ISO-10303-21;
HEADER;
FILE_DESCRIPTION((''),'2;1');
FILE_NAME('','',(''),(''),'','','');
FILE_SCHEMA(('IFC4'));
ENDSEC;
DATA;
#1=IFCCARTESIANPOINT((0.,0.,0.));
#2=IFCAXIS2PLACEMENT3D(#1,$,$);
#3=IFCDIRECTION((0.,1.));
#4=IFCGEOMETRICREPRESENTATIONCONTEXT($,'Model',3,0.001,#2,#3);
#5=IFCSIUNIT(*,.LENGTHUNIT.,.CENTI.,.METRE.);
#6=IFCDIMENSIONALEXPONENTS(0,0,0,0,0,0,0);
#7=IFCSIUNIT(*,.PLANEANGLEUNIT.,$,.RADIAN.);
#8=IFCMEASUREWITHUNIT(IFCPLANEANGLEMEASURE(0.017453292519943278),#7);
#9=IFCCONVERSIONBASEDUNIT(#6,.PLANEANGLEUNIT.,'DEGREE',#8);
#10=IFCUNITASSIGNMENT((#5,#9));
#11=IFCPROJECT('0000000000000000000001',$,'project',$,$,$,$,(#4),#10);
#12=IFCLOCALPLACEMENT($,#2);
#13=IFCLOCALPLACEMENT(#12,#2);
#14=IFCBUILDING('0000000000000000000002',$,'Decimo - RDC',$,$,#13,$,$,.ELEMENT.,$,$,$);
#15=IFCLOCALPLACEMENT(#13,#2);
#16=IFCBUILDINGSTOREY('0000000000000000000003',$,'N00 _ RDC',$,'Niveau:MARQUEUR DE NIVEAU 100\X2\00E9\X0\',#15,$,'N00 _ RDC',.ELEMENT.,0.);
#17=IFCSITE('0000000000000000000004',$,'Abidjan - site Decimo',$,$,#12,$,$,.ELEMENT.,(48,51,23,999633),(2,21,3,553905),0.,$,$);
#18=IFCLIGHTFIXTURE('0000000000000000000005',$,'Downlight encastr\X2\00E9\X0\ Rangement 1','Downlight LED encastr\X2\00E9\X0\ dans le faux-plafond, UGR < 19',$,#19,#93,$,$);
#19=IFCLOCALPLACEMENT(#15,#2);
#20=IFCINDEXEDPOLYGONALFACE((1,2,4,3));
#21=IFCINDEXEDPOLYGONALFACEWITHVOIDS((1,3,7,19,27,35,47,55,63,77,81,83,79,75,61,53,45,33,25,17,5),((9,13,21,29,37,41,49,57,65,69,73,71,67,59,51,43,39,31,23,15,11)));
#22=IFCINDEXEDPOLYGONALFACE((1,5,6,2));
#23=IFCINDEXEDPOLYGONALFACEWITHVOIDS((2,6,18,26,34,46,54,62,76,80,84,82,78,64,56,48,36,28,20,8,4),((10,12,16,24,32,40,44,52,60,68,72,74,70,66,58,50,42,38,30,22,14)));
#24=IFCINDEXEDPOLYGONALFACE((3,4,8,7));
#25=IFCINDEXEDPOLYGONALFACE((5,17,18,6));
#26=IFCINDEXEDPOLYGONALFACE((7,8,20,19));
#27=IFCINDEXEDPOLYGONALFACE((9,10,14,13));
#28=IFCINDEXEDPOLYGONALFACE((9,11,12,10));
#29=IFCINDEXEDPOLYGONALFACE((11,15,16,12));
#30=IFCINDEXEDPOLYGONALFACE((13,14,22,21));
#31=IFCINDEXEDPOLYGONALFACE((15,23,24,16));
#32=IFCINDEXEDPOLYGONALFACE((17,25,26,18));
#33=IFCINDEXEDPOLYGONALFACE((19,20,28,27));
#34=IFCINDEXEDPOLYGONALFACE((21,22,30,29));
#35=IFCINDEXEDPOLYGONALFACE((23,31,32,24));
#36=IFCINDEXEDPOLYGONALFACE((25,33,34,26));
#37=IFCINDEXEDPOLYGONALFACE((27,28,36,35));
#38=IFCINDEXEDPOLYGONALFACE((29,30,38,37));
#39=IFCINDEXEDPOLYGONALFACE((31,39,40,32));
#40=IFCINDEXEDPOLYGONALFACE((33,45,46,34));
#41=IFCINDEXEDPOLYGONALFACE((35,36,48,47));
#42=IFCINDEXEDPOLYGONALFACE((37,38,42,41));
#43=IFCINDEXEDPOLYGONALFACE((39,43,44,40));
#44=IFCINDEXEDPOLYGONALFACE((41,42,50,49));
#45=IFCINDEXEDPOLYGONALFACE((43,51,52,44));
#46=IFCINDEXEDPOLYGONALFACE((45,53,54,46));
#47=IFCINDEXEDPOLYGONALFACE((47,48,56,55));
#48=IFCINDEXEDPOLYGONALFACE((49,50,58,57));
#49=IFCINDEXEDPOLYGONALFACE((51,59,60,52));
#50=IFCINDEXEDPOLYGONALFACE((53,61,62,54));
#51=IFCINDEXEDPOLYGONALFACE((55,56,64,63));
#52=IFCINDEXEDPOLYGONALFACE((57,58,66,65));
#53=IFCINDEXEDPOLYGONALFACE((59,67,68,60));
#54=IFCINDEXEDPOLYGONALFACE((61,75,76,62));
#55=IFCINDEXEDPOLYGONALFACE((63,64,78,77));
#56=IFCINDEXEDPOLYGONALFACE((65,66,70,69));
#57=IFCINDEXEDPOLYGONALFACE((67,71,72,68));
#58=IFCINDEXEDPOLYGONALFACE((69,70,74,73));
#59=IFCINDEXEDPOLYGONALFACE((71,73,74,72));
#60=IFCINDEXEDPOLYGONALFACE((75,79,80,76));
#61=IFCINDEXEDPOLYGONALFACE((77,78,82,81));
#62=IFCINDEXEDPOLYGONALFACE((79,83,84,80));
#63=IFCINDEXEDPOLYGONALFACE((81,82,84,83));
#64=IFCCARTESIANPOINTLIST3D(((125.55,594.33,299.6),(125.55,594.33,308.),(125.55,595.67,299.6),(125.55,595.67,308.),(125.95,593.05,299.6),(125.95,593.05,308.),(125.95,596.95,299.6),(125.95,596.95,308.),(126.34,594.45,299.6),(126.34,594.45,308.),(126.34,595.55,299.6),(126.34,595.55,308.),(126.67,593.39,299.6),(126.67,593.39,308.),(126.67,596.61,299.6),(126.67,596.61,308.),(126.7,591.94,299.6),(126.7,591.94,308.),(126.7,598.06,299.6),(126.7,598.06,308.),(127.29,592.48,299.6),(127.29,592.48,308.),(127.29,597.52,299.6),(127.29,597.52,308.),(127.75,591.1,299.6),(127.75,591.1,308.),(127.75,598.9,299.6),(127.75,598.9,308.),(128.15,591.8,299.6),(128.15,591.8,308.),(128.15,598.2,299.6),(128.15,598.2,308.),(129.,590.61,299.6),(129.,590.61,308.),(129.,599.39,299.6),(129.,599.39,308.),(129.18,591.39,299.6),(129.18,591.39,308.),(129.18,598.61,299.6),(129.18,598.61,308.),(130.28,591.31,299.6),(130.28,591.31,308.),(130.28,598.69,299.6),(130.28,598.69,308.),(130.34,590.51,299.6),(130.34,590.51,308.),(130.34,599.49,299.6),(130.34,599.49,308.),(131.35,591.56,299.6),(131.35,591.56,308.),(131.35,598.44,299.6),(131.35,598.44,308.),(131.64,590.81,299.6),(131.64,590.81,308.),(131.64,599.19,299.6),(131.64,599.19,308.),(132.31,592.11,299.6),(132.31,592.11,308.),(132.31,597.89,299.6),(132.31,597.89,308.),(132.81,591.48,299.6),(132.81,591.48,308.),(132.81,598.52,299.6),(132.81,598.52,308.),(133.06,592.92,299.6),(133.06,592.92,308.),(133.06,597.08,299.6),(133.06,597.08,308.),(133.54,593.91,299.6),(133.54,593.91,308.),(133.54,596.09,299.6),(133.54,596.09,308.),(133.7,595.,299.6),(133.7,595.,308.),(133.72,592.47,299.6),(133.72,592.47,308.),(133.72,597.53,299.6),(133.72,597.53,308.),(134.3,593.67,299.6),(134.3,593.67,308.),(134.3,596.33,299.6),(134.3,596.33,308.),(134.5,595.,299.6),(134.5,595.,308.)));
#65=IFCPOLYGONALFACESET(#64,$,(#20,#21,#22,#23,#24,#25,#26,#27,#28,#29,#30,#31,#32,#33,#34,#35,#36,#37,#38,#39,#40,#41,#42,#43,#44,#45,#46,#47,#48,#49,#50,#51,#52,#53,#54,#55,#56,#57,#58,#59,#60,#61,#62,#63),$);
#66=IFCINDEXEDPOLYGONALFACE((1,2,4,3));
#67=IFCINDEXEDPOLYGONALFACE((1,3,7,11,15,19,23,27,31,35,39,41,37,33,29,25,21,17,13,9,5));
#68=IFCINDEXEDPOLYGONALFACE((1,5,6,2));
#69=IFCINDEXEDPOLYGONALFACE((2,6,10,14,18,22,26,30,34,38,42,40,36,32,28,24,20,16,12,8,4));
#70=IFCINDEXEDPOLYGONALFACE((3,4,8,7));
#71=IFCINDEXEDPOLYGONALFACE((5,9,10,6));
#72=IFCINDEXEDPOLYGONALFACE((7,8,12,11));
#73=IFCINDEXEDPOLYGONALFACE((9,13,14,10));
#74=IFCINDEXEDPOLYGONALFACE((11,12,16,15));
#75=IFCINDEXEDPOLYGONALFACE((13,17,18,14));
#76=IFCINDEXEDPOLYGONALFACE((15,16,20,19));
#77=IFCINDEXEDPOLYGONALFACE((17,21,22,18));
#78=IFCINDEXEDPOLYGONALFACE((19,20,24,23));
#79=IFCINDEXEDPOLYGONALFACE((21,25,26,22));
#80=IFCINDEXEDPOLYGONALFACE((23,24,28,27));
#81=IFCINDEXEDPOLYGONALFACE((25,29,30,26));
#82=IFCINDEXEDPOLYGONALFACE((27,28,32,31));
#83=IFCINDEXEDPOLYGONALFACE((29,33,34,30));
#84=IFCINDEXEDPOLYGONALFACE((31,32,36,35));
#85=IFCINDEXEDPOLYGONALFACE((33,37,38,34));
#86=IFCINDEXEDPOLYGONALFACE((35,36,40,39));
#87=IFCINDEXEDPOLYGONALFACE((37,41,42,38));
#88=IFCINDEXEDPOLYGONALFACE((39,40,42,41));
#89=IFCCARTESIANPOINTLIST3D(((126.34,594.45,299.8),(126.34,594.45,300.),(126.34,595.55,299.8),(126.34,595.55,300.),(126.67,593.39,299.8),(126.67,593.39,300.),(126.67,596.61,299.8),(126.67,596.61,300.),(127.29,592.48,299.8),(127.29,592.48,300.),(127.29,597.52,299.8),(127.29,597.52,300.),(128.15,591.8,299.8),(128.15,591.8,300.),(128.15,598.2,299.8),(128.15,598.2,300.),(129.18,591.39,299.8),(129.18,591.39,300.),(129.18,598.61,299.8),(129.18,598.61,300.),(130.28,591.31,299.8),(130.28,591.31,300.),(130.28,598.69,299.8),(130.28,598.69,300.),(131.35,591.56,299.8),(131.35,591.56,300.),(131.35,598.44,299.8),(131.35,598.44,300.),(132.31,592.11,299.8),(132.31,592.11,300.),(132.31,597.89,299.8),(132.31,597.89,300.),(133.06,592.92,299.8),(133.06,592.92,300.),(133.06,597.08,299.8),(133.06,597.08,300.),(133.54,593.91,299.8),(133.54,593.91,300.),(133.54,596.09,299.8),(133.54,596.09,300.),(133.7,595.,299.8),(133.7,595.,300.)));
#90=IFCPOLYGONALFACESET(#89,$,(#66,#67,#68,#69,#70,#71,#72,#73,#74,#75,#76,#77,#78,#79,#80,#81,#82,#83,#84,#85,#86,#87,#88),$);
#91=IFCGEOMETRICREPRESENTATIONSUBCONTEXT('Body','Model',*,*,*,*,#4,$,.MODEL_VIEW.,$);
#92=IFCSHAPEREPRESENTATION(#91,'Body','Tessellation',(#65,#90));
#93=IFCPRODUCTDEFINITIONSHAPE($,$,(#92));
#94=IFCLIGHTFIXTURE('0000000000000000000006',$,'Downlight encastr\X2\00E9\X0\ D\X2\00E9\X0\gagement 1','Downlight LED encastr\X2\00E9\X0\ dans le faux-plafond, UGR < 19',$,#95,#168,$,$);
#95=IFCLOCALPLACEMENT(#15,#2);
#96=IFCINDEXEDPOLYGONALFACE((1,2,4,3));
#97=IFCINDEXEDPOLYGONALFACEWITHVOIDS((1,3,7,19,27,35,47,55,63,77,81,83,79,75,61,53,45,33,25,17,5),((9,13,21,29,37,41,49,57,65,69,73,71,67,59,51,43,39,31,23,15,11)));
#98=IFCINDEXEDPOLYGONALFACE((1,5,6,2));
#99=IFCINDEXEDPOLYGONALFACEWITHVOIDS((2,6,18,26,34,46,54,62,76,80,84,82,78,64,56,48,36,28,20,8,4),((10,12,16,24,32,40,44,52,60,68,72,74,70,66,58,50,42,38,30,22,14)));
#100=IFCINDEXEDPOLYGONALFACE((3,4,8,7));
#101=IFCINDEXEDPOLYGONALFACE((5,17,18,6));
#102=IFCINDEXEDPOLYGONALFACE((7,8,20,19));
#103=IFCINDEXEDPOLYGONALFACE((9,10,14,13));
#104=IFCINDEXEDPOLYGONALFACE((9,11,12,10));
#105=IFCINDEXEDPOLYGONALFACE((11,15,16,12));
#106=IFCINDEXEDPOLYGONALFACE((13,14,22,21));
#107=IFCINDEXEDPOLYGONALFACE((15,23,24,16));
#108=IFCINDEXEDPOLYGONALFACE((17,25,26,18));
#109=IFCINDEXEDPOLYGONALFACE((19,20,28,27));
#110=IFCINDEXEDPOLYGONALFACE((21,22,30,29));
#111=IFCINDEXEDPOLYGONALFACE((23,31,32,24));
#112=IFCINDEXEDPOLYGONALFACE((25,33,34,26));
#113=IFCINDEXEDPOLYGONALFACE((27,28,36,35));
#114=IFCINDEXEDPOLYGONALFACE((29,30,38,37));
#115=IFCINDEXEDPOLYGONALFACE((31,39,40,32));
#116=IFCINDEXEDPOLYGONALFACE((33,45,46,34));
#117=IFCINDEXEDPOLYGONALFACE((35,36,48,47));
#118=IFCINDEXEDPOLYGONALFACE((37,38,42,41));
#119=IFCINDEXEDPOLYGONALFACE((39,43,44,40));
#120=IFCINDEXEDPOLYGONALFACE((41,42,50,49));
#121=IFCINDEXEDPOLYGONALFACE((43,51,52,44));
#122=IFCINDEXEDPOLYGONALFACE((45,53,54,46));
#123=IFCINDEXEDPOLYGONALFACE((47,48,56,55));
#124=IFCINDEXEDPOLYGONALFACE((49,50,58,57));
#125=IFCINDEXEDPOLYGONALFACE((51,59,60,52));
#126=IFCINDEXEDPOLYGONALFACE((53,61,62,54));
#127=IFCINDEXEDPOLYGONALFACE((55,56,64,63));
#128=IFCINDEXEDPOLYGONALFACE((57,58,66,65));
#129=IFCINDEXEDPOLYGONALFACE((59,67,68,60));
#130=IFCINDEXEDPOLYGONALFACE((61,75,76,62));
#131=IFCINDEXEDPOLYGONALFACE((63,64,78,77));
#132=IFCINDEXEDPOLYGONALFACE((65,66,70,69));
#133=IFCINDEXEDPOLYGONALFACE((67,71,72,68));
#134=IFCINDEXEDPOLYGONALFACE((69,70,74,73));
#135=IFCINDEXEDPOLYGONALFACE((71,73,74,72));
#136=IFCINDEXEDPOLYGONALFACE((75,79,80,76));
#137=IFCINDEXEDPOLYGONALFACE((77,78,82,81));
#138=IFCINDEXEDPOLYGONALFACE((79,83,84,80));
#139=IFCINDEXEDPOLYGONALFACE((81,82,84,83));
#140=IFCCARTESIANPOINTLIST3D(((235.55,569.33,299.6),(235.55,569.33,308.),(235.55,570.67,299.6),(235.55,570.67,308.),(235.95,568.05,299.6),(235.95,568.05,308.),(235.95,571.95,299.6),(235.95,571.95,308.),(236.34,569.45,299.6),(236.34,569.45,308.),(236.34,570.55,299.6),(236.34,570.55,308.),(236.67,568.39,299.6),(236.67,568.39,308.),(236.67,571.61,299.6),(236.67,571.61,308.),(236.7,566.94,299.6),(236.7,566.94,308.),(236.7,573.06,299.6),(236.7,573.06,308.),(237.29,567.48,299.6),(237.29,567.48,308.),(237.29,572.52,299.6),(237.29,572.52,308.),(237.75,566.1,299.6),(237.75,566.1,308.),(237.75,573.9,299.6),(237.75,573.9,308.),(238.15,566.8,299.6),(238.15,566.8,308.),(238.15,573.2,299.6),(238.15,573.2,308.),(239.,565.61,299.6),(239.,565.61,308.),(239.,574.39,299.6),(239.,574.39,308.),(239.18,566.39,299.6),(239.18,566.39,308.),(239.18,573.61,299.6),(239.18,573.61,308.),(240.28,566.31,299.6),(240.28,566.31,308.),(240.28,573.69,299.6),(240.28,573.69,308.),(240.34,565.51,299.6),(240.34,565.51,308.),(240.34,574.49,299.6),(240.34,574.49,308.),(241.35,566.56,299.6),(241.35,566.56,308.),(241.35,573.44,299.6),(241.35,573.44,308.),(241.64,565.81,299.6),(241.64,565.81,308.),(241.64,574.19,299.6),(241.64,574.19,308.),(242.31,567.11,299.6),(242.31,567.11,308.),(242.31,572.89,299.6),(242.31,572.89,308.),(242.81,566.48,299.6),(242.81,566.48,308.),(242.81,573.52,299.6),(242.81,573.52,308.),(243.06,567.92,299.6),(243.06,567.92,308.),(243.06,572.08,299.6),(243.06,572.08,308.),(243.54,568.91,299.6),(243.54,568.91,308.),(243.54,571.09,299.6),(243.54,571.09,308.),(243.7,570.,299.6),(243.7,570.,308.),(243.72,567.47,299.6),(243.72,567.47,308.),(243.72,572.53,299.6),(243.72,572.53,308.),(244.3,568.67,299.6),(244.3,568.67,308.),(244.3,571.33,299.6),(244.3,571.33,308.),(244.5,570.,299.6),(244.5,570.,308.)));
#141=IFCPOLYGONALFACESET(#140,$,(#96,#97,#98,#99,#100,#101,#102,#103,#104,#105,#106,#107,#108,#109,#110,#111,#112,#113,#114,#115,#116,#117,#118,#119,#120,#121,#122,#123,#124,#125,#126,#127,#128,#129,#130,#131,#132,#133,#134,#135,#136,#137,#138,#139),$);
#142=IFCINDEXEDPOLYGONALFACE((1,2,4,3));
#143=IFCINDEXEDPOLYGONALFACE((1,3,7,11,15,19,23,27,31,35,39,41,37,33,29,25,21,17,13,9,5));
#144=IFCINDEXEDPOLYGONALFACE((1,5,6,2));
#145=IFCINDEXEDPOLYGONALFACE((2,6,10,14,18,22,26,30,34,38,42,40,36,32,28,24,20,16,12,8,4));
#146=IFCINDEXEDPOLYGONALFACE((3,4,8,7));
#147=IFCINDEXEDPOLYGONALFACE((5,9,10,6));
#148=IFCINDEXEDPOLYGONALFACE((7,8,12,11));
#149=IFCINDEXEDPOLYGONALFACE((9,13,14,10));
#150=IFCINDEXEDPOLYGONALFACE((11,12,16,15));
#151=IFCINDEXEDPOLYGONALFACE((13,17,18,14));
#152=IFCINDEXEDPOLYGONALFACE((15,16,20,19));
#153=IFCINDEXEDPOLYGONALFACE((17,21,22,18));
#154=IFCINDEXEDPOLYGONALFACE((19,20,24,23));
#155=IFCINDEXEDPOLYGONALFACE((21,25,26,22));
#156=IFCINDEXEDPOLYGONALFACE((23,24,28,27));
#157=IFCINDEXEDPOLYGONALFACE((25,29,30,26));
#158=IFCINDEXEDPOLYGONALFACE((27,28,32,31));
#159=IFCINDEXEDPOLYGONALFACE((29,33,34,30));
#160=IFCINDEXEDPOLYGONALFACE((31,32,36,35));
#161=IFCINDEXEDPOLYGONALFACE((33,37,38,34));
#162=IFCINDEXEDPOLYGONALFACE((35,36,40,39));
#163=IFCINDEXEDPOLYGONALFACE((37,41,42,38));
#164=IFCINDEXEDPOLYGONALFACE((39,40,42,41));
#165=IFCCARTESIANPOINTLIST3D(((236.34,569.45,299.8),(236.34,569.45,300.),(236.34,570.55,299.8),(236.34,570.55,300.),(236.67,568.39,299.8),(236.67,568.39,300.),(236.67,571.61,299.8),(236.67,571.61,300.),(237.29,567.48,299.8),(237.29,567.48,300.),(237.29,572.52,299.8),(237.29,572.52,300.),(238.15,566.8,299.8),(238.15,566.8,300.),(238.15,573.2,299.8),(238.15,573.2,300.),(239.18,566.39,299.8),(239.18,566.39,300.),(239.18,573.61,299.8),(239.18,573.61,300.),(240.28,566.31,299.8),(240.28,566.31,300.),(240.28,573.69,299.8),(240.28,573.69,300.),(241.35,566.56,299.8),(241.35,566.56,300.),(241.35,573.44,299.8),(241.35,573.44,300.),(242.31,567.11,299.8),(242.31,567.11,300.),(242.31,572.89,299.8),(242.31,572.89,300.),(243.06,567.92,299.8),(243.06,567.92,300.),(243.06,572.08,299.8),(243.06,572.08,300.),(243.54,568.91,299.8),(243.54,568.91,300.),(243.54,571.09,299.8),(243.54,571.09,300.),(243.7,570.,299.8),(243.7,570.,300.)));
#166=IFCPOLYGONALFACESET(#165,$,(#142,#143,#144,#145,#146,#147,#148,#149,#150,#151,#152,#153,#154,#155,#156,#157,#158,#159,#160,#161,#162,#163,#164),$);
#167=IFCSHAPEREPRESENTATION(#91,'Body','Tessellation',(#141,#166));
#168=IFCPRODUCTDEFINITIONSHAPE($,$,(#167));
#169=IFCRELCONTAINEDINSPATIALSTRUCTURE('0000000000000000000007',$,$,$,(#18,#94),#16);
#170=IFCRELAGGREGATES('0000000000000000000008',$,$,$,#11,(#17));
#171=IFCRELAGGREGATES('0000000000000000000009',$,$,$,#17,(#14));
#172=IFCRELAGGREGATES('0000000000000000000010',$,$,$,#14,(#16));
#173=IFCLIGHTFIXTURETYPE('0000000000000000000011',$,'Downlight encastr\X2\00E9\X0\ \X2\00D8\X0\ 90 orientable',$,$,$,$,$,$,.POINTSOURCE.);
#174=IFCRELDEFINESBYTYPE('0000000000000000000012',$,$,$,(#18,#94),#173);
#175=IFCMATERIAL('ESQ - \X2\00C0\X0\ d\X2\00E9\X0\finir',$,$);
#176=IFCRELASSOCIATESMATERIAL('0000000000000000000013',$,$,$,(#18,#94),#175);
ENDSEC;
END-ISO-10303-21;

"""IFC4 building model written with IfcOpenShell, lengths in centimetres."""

from ifc_helpers import new_model, entity, si_unit, converted_unit, direction, frame, frame_2d, origin, origin_with_axes, place, context, subcontext, project, spatial, circle, hollow_circle, extrude, material, type_object, element, save


model = new_model("IFC4")

# Units and contexts
model_context = context("Model", 3, precision=0.001, world=origin(), true_north=direction((0.0, 1.0)))
body_context = subcontext(model_context, "Body", "Model", "MODEL_VIEW")
ifc_project = project(units=[si_unit("LENGTHUNIT", "METRE", prefix="CENTI"), converted_unit("PLANEANGLEUNIT", "DEGREE", entity("IfcPlaneAngleMeasure", 0.017453292519943278), si_unit("PLANEANGLEUNIT", "RADIAN"), dimensions=[0, 0, 0, 0, 0, 0, 0])], contexts=[model_context])

# Site, building, storey
site_placement = place(None, origin())
site = spatial("IfcSite", under=ifc_project, at=site_placement, Name="Abidjan - site Decimo", CompositionType="ELEMENT", RefLatitude=(48, 51, 23, 999633), RefLongitude=(2, 21, 3, 553905), RefElevation=0.0)
building_placement = place(site_placement, origin())
building = spatial("IfcBuilding", under=site, at=building_placement, Name="Decimo - RDC", CompositionType="ELEMENT")
storey_placement = place(building_placement, origin())
storey = spatial("IfcBuildingStorey", under=building, at=storey_placement, Name="N00 _ RDC", ObjectType="Niveau:MARQUEUR DE NIVEAU 100é", LongName="N00 _ RDC", CompositionType="ELEMENT", Elevation=0.0)

# Light fixtures
ifc_material_1 = material(Name="ESQ - À définir")
light_fixture_type_1 = type_object("IfcLightFixtureType", Name="Downlight encastré Ø 90 orientable", PredefinedType="POINTSOURCE")
light_fixture_1_placement = place(storey_placement, origin_with_axes())
element("IfcLightFixture", 1, at=light_fixture_1_placement, inside=storey, type_object=light_fixture_type_1, material=ifc_material_1, Name="Downlight encastré Rangement 1", Description="Downlight LED encastré dans le faux-plafond, UGR < 19", context=body_context, shape_type="SweptSolid", body=[
    extrude(hollow_circle(Radius=4.5, WallThickness=0.8, at=frame_2d((130.0, 595.0))), frame((0.0, 0.0, 299.6)), (0.0, 0.0, 1.0), 8.4),
    extrude(circle(Radius=3.7, at=frame_2d((130.0, 595.0))), frame((0.0, 0.0, 299.8)), (0.0, 0.0, 1.0), 0.2),
])
light_fixture_2_placement = place(storey_placement, origin_with_axes())
element("IfcLightFixture", 2, at=light_fixture_2_placement, inside=storey, type_object=light_fixture_type_1, material=ifc_material_1, Name="Downlight encastré Dégagement 1", Description="Downlight LED encastré dans le faux-plafond, UGR < 19", context=body_context, shape_type="SweptSolid", body=[
    extrude(hollow_circle(Radius=4.5, WallThickness=0.8, at=frame_2d((240.0, 570.0))), frame((0.0, 0.0, 299.6)), (0.0, 0.0, 1.0), 8.4),
    extrude(circle(Radius=3.7, at=frame_2d((240.0, 570.0))), frame((0.0, 0.0, 299.8)), (0.0, 0.0, 1.0), 0.2),
])

save(model, "model.ifc")
